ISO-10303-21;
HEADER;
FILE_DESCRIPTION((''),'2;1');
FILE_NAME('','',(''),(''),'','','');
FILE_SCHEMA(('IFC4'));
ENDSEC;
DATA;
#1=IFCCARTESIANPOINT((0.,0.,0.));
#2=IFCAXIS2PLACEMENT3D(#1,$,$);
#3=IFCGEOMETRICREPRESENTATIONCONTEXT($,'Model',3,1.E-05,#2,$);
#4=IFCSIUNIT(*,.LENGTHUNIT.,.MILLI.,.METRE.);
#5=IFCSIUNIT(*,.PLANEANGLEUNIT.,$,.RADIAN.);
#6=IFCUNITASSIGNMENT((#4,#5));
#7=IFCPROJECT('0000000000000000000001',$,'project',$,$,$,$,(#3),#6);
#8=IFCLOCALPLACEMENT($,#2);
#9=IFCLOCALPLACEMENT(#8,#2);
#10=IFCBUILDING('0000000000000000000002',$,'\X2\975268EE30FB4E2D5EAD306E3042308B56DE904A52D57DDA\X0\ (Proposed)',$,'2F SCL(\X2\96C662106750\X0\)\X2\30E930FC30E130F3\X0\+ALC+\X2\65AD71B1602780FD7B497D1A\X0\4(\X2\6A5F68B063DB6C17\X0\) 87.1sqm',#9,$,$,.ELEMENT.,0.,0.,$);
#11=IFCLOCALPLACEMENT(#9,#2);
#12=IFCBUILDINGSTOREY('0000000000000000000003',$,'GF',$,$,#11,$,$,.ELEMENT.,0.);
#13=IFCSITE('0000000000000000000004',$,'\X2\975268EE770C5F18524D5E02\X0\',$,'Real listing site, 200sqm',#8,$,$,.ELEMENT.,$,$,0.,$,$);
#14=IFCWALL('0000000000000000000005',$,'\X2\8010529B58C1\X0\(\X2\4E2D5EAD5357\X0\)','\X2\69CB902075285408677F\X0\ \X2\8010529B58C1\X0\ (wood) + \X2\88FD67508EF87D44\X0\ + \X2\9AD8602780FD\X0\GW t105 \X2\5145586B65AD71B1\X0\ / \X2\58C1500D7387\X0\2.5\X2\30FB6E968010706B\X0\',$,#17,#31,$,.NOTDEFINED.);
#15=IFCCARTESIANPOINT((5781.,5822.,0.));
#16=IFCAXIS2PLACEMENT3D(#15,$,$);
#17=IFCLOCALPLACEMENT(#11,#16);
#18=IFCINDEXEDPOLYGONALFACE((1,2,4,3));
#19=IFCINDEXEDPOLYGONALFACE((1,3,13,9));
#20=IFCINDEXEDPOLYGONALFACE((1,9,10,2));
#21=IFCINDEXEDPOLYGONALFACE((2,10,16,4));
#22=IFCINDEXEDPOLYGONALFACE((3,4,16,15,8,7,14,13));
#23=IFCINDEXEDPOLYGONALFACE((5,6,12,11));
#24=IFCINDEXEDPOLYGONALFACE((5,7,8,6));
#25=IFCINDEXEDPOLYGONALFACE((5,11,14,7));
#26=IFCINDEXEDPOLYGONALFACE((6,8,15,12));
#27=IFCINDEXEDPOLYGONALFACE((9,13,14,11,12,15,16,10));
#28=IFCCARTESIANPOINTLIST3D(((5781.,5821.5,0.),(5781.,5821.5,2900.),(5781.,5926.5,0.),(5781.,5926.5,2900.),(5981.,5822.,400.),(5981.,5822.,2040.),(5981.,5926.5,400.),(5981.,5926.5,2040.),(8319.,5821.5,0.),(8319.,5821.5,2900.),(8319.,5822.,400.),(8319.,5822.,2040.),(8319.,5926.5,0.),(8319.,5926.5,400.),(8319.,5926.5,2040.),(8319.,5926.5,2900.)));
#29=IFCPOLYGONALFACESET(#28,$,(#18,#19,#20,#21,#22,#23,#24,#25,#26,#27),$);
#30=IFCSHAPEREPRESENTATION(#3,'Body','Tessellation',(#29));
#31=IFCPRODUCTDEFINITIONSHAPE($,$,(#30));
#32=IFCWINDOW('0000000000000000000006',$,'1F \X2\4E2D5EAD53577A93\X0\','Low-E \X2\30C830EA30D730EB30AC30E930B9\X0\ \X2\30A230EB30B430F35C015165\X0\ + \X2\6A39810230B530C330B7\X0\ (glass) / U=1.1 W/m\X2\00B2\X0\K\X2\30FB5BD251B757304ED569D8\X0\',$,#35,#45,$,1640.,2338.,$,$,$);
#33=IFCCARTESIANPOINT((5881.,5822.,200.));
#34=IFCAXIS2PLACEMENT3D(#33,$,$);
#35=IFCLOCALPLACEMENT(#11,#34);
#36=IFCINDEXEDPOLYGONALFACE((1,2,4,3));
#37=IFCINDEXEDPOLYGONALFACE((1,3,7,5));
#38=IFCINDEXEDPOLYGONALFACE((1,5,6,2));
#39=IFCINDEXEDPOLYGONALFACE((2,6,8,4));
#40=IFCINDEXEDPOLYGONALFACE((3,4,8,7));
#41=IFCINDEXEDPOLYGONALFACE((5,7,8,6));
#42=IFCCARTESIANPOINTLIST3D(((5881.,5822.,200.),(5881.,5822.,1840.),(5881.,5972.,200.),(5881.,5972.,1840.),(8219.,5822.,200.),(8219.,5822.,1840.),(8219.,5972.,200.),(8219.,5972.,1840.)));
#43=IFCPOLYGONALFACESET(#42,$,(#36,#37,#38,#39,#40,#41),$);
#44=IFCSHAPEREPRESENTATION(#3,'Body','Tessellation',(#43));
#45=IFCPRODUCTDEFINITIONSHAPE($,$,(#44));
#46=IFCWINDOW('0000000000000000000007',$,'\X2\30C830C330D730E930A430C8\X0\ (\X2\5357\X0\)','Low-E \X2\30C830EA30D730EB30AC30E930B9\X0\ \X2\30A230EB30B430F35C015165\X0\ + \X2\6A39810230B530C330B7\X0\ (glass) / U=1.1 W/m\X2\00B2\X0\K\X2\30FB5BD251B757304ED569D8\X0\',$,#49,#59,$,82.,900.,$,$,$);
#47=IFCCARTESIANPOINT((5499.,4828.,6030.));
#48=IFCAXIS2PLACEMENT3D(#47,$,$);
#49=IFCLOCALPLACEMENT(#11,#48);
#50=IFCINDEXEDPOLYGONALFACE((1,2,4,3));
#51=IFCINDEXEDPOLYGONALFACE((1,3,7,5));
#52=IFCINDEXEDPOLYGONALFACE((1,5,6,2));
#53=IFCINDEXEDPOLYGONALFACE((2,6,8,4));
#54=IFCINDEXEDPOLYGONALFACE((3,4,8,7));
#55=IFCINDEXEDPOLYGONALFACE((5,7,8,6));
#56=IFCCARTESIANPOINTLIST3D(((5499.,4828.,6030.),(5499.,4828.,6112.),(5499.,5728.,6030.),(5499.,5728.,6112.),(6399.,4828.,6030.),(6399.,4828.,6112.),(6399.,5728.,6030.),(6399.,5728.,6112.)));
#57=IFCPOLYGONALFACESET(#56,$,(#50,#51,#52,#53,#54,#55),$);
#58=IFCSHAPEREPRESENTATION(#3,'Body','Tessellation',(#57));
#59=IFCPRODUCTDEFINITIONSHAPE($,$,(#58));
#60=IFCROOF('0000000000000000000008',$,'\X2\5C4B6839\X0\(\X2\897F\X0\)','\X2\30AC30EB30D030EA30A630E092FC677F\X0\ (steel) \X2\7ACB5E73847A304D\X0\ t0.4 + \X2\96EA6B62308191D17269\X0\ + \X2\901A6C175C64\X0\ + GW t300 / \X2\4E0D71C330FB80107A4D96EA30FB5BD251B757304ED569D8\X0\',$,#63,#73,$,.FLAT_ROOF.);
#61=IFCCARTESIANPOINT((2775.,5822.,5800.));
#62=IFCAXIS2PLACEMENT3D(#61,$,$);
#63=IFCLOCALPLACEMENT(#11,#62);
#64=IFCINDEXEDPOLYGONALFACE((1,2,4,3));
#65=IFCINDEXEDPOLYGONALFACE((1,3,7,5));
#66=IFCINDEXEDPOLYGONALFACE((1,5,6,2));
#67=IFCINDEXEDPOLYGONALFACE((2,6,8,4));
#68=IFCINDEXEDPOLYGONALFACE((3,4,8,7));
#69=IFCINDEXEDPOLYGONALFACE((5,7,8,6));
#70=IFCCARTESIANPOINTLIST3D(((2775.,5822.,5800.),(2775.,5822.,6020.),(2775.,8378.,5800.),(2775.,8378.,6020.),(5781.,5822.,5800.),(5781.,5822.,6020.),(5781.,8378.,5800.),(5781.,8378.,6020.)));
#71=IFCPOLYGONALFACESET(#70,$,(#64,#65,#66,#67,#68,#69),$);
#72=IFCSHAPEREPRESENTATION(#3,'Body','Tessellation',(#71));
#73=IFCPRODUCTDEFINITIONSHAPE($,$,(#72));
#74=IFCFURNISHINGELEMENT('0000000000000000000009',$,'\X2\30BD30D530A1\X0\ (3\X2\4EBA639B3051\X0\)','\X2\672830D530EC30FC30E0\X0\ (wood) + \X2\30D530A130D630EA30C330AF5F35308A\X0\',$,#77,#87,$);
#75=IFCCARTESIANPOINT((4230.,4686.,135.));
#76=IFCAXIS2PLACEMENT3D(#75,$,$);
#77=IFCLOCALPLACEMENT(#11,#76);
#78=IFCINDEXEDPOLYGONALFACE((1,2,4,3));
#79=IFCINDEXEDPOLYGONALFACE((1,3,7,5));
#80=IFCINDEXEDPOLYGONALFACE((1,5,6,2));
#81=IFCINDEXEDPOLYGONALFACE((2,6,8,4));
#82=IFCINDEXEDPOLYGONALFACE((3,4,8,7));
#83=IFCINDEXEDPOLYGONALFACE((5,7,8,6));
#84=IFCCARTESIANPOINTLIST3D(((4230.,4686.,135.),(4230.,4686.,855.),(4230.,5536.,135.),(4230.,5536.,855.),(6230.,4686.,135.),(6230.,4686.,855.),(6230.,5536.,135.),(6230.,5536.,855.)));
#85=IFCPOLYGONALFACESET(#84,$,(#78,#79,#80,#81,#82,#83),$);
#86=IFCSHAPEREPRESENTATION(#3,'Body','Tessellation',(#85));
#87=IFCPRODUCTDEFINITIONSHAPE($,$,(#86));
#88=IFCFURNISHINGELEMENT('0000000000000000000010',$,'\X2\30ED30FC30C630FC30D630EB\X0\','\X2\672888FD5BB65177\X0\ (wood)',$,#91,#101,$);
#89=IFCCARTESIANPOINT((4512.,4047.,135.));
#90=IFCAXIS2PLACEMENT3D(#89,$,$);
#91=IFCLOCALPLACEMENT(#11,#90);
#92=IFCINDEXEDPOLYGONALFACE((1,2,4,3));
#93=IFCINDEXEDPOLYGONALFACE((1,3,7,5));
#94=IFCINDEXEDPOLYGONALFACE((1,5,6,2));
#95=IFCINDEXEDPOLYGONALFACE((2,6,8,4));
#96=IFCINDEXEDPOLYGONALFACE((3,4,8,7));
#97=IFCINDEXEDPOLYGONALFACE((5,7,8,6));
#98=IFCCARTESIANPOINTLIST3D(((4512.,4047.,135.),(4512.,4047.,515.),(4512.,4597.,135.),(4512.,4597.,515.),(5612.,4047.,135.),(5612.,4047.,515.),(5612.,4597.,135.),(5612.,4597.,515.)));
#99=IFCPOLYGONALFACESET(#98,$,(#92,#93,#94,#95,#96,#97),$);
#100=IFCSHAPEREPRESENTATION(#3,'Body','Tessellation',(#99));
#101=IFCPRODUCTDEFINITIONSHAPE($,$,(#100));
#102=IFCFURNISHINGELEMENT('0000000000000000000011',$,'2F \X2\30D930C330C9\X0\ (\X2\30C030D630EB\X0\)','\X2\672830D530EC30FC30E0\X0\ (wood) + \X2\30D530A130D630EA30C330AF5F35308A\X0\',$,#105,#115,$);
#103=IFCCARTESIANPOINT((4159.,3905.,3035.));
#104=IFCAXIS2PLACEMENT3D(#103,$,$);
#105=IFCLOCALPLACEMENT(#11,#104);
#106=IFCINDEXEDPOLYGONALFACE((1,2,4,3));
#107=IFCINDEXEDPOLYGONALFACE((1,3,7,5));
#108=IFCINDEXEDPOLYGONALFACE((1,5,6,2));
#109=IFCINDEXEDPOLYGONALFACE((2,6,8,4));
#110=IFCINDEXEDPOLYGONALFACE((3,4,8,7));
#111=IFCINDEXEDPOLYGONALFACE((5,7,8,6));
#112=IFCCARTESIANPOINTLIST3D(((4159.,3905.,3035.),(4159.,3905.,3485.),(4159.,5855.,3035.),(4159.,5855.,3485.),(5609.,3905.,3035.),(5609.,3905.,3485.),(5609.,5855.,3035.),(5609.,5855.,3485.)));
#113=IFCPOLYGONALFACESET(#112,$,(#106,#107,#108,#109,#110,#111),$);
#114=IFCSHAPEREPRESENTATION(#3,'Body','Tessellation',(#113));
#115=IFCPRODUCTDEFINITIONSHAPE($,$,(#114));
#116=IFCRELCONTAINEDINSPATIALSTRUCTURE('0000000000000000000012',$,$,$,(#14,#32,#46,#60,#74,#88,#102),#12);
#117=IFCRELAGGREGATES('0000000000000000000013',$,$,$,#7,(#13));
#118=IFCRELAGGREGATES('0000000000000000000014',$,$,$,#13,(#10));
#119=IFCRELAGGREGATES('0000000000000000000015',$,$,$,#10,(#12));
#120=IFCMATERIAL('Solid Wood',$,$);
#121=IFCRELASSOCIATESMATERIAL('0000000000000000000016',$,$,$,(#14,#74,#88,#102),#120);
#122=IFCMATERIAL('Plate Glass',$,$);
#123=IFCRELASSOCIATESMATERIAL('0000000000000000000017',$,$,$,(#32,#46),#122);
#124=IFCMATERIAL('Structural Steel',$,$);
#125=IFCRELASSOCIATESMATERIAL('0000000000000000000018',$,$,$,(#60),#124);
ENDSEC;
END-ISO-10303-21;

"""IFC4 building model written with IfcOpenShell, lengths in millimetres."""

from ifc_helpers import new_model, si_unit, frame, frame_2d, origin, place, context, project, spatial, rectangle, extrude, material, element, fill, save


model = new_model("IFC4")

# Units and contexts
model_context = context("Model", 3, precision=1e-05, world=origin())
ifc_project = project(units=[si_unit("LENGTHUNIT", "METRE", prefix="MILLI"), si_unit("PLANEANGLEUNIT", "RADIAN")], contexts=[model_context])

# Site, building, storey
site_placement = place(None, origin())
site = spatial("IfcSite", under=ifc_project, at=site_placement, Name="青森県弘前市", ObjectType="Real listing site, 200sqm", CompositionType="ELEMENT", RefElevation=0.0)
building_placement = place(site_placement, origin())
building = spatial("IfcBuilding", under=site, at=building_placement, Name="青森・中庭のある回遊動線 (Proposed)", ObjectType="2F SCL(集成材)ラーメン+ALC+断熱性能等級4(機械換気) 87.1sqm", CompositionType="ELEMENT", ElevationOfRefHeight=0.0, ElevationOfTerrain=0.0)
storey_placement = place(building_placement, origin())
storey = spatial("IfcBuildingStorey", under=building, at=storey_placement, Name="GF", CompositionType="ELEMENT", Elevation=0.0)

# Shared definitions
ifc_material_1 = material(Name="Solid Wood")

# Wall, opening, window
wall_placement = place(storey_placement, frame((5781.0, 5822.0, 0.0)))
wall = element("IfcWall", 1, at=wall_placement, inside=storey, material=ifc_material_1, Name="耐力壁(中庭南)", Description="構造用合板 耐力壁 (wood) + 製材軸組 + 高性能GW t105 充填断熱 / 壁倍率2.5・準耐火", PredefinedType="NOTDEFINED", context=model_context, shape_type="SweptSolid", body=[
    extrude(rectangle(XDim=2538.0, YDim=105.0, at=frame_2d((1269.0, 52.0))), frame((5781.0, 5822.0, 0.0)), (0.0, 0.0, 1.0), 2900.0),
])
opening_placement = place(storey_placement, frame((5881.0, 5822.0, 200.0)))
opening = element("IfcOpeningElement", 2, at=opening_placement, cuts=wall, PredefinedType="NOTDEFINED", context=model_context, shape_type="SweptSolid", body=[
    extrude(rectangle(XDim=2338.0, YDim=150.0, at=frame_2d((1169.0, 75.0))), frame((5881.0, 5822.0, 200.0)), (0.0, 0.0, 1.0), 1640.0),
])
ifc_material_2 = material(Name="Plate Glass")
window_1_placement = place(storey_placement, frame((5881.0, 5822.0, 200.0)))
window_1 = element("IfcWindow", 3, at=window_1_placement, inside=storey, material=ifc_material_2, Name="1F 中庭南窓", Description="Low-E トリプルガラス アルゴン封入 + 樹脂サッシ (glass) / U=1.1 W/m²K・寒冷地仕様", OverallHeight=1640.0, OverallWidth=2338.0, context=model_context, shape_type="SweptSolid", body=[
    extrude(rectangle(XDim=2338.0, YDim=150.0, at=frame_2d((1169.0, 75.0))), frame((5881.0, 5822.0, 200.0)), (0.0, 0.0, 1.0), 1640.0),
])
fill(opening, window_1)

# Window
window_2_placement = place(storey_placement, frame((5499.0, 4828.0, 6030.0)))
element("IfcWindow", 4, at=window_2_placement, inside=storey, material=ifc_material_2, Name="トップライト (南)", Description="Low-E トリプルガラス アルゴン封入 + 樹脂サッシ (glass) / U=1.1 W/m²K・寒冷地仕様", OverallHeight=82.0, OverallWidth=900.0, context=model_context, shape_type="SweptSolid", body=[
    extrude(rectangle(XDim=900.0, YDim=900.0, at=frame_2d((450.0, 450.0))), frame((5499.0, 4828.0, 6030.0)), (0.0, 0.0, 1.0), 82.0),
])

# Roof
ifc_material_3 = material(Name="Structural Steel")
for number, where, name in (
    (5, (2775.0, 5822.0, 5800.0), "屋根(西)"),
):
    element("IfcRoof", number, at=place(storey_placement, frame(where)), inside=storey, material=ifc_material_3, Name=name, Description="ガルバリウム鋼板 (steel) 立平葺き t0.4 + 雪止め金物 + 通気層 + GW t300 / 不燃・耐積雪・寒冷地仕様", PredefinedType="FLAT_ROOF", context=model_context, shape_type="SweptSolid", body=[
        extrude(rectangle(XDim=3006.0, YDim=2556.0, at=frame_2d((1503.0, 1278.0))), frame((2775.0, 5822.0, 5800.0)), (0.0, 0.0, 1.0), 220.0),
    ])

# Furnishing elements
furnishing_1_placement = place(storey_placement, frame((4230.0, 4686.0, 135.0)))
element("IfcFurnishingElement", 6, at=furnishing_1_placement, inside=storey, material=ifc_material_1, Name="ソファ (3人掛け)", Description="木フレーム (wood) + ファブリック張り", context=model_context, shape_type="SweptSolid", body=[
    extrude(rectangle(XDim=2000.0, YDim=850.0, at=frame_2d((1000.0, 425.0))), frame((4230.0, 4686.0, 135.0)), (0.0, 0.0, 1.0), 720.0),
])
furnishing_2_placement = place(storey_placement, frame((4512.0, 4047.0, 135.0)))
element("IfcFurnishingElement", 7, at=furnishing_2_placement, inside=storey, material=ifc_material_1, Name="ローテーブル", Description="木製家具 (wood)", context=model_context, shape_type="SweptSolid", body=[
    extrude(rectangle(XDim=1100.0, YDim=550.0, at=frame_2d((550.0, 275.0))), frame((4512.0, 4047.0, 135.0)), (0.0, 0.0, 1.0), 380.0),
])
furnishing_3_placement = place(storey_placement, frame((4159.0, 3905.0, 3035.0)))
element("IfcFurnishingElement", 8, at=furnishing_3_placement, inside=storey, material=ifc_material_1, Name="2F ベッド (ダブル)", Description="木フレーム (wood) + ファブリック張り", context=model_context, shape_type="SweptSolid", body=[
    extrude(rectangle(XDim=1450.0, YDim=1950.0, at=frame_2d((725.0, 975.0))), frame((4159.0, 3905.0, 3035.0)), (0.0, 0.0, 1.0), 450.0),
])

save(model, "model.ifc")
